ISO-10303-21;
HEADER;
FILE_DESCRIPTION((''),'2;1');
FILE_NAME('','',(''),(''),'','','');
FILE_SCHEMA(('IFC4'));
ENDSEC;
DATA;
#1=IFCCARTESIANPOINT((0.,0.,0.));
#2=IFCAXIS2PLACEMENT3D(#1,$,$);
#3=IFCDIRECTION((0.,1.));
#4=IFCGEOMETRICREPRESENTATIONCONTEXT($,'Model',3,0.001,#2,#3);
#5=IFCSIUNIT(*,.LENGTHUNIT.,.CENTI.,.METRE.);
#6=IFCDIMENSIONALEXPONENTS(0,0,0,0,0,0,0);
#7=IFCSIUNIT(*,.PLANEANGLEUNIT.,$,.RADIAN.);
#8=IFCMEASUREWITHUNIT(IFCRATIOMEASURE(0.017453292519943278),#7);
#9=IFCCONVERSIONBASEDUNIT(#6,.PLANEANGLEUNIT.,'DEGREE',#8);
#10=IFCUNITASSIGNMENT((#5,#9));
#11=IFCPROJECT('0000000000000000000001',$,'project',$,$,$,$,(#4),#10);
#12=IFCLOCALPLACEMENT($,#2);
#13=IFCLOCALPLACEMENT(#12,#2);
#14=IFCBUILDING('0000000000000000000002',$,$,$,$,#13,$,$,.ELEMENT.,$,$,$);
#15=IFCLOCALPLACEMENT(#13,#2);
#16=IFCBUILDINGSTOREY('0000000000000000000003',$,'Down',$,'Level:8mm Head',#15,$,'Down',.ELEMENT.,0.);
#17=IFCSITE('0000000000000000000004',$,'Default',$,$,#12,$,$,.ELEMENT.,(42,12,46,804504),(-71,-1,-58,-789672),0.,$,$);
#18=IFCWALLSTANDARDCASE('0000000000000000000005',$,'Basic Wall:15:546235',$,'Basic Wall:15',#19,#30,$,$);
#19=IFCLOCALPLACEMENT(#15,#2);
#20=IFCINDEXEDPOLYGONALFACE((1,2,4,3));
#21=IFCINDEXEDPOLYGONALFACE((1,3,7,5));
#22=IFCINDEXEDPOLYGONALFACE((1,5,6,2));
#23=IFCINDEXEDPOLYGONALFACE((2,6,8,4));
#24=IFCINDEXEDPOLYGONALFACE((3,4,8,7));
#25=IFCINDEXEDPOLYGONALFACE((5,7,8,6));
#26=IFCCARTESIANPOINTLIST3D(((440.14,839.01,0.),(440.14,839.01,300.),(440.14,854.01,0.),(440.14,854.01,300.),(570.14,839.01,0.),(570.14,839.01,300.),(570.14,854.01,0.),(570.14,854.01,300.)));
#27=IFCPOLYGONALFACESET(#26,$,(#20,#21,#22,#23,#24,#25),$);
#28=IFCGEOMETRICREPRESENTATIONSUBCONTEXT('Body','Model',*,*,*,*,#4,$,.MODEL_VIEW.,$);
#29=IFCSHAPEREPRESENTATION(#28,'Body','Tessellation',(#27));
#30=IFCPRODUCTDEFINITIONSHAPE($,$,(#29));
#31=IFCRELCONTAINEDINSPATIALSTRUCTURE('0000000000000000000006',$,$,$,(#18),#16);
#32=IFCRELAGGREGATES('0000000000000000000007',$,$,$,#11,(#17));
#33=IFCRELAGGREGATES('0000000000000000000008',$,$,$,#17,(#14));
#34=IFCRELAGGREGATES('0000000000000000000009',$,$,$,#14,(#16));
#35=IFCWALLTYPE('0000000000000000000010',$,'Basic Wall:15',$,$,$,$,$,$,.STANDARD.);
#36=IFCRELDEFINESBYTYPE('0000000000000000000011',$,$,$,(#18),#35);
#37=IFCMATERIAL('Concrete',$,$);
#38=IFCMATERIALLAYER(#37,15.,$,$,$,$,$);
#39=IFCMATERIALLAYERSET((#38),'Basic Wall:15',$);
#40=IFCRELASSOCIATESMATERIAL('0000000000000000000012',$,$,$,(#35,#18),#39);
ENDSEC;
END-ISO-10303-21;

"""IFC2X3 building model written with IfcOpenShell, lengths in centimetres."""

from ifc_helpers import new_model, entity, si_unit, converted_unit, direction, frame, frame_2d, origin, place, context, subcontext, project, spatial, rectangle, extrude, material, layer, layer_set, layer_usage, type_object, element, save


model = new_model("IFC2X3")

# Units and contexts
model_context = context("Model", 3, precision=0.001, world=origin(), true_north=direction((0.0, 1.0)))
body_context = subcontext(model_context, "Body", "Model", "MODEL_VIEW")
ifc_project = project(units=[si_unit("LENGTHUNIT", "METRE", prefix="CENTI"), converted_unit("PLANEANGLEUNIT", "DEGREE", entity("IfcRatioMeasure", 0.017453292519943278), si_unit("PLANEANGLEUNIT", "RADIAN"), dimensions=[0, 0, 0, 0, 0, 0, 0])], contexts=[model_context])

# Site, building, storey
site_placement = place(None, origin())
site = spatial("IfcSite", under=ifc_project, at=site_placement, Name="Default", CompositionType="ELEMENT", RefLatitude=(42, 12, 46, 804504), RefLongitude=(-71, -1, -58, -789672), RefElevation=0.0)
building_placement = place(site_placement, origin())
building = spatial("IfcBuilding", under=site, at=building_placement, CompositionType="ELEMENT")
storey_placement = place(building_placement, origin())
storey = spatial("IfcBuildingStorey", under=building, at=storey_placement, Name="Down", ObjectType="Level:8mm Head", LongName="Down", CompositionType="ELEMENT", Elevation=0.0)

# Wall
ifc_material = material(Name="Concrete")
ifc_layer_1 = layer(ifc_material, 15.0)
ifc_layer_set_1 = layer_set([ifc_layer_1], Name="Basic Wall:15")
ifc_layer_usage_1 = layer_usage(ifc_layer_set_1, "AXIS2", "NEGATIVE", 7.5)
wall_type_1 = type_object("IfcWallType", Name="Basic Wall:15", PredefinedType="STANDARD", material=ifc_layer_set_1)
wall_1_placement = place(storey_placement, frame((570.14, 846.51, 0.0), z_axis=(0.0, 0.0, 1.0), x_axis=(-1.0, 0.0, 0.0)))
element("IfcWallStandardCase", 1, at=wall_1_placement, inside=storey, type_object=wall_type_1, material=ifc_layer_usage_1, Name="Basic Wall:15:546235", ObjectType="Basic Wall:15", context=body_context, shape_type="SweptSolid", body=[
    extrude(rectangle(XDim=130.0, YDim=15.0, at=frame_2d((65.0, 0.0), x_axis=(-1.0, 0.0))), origin(), (0.0, 0.0, 1.0), 300.0),
])

save(model, "model.ifc")
